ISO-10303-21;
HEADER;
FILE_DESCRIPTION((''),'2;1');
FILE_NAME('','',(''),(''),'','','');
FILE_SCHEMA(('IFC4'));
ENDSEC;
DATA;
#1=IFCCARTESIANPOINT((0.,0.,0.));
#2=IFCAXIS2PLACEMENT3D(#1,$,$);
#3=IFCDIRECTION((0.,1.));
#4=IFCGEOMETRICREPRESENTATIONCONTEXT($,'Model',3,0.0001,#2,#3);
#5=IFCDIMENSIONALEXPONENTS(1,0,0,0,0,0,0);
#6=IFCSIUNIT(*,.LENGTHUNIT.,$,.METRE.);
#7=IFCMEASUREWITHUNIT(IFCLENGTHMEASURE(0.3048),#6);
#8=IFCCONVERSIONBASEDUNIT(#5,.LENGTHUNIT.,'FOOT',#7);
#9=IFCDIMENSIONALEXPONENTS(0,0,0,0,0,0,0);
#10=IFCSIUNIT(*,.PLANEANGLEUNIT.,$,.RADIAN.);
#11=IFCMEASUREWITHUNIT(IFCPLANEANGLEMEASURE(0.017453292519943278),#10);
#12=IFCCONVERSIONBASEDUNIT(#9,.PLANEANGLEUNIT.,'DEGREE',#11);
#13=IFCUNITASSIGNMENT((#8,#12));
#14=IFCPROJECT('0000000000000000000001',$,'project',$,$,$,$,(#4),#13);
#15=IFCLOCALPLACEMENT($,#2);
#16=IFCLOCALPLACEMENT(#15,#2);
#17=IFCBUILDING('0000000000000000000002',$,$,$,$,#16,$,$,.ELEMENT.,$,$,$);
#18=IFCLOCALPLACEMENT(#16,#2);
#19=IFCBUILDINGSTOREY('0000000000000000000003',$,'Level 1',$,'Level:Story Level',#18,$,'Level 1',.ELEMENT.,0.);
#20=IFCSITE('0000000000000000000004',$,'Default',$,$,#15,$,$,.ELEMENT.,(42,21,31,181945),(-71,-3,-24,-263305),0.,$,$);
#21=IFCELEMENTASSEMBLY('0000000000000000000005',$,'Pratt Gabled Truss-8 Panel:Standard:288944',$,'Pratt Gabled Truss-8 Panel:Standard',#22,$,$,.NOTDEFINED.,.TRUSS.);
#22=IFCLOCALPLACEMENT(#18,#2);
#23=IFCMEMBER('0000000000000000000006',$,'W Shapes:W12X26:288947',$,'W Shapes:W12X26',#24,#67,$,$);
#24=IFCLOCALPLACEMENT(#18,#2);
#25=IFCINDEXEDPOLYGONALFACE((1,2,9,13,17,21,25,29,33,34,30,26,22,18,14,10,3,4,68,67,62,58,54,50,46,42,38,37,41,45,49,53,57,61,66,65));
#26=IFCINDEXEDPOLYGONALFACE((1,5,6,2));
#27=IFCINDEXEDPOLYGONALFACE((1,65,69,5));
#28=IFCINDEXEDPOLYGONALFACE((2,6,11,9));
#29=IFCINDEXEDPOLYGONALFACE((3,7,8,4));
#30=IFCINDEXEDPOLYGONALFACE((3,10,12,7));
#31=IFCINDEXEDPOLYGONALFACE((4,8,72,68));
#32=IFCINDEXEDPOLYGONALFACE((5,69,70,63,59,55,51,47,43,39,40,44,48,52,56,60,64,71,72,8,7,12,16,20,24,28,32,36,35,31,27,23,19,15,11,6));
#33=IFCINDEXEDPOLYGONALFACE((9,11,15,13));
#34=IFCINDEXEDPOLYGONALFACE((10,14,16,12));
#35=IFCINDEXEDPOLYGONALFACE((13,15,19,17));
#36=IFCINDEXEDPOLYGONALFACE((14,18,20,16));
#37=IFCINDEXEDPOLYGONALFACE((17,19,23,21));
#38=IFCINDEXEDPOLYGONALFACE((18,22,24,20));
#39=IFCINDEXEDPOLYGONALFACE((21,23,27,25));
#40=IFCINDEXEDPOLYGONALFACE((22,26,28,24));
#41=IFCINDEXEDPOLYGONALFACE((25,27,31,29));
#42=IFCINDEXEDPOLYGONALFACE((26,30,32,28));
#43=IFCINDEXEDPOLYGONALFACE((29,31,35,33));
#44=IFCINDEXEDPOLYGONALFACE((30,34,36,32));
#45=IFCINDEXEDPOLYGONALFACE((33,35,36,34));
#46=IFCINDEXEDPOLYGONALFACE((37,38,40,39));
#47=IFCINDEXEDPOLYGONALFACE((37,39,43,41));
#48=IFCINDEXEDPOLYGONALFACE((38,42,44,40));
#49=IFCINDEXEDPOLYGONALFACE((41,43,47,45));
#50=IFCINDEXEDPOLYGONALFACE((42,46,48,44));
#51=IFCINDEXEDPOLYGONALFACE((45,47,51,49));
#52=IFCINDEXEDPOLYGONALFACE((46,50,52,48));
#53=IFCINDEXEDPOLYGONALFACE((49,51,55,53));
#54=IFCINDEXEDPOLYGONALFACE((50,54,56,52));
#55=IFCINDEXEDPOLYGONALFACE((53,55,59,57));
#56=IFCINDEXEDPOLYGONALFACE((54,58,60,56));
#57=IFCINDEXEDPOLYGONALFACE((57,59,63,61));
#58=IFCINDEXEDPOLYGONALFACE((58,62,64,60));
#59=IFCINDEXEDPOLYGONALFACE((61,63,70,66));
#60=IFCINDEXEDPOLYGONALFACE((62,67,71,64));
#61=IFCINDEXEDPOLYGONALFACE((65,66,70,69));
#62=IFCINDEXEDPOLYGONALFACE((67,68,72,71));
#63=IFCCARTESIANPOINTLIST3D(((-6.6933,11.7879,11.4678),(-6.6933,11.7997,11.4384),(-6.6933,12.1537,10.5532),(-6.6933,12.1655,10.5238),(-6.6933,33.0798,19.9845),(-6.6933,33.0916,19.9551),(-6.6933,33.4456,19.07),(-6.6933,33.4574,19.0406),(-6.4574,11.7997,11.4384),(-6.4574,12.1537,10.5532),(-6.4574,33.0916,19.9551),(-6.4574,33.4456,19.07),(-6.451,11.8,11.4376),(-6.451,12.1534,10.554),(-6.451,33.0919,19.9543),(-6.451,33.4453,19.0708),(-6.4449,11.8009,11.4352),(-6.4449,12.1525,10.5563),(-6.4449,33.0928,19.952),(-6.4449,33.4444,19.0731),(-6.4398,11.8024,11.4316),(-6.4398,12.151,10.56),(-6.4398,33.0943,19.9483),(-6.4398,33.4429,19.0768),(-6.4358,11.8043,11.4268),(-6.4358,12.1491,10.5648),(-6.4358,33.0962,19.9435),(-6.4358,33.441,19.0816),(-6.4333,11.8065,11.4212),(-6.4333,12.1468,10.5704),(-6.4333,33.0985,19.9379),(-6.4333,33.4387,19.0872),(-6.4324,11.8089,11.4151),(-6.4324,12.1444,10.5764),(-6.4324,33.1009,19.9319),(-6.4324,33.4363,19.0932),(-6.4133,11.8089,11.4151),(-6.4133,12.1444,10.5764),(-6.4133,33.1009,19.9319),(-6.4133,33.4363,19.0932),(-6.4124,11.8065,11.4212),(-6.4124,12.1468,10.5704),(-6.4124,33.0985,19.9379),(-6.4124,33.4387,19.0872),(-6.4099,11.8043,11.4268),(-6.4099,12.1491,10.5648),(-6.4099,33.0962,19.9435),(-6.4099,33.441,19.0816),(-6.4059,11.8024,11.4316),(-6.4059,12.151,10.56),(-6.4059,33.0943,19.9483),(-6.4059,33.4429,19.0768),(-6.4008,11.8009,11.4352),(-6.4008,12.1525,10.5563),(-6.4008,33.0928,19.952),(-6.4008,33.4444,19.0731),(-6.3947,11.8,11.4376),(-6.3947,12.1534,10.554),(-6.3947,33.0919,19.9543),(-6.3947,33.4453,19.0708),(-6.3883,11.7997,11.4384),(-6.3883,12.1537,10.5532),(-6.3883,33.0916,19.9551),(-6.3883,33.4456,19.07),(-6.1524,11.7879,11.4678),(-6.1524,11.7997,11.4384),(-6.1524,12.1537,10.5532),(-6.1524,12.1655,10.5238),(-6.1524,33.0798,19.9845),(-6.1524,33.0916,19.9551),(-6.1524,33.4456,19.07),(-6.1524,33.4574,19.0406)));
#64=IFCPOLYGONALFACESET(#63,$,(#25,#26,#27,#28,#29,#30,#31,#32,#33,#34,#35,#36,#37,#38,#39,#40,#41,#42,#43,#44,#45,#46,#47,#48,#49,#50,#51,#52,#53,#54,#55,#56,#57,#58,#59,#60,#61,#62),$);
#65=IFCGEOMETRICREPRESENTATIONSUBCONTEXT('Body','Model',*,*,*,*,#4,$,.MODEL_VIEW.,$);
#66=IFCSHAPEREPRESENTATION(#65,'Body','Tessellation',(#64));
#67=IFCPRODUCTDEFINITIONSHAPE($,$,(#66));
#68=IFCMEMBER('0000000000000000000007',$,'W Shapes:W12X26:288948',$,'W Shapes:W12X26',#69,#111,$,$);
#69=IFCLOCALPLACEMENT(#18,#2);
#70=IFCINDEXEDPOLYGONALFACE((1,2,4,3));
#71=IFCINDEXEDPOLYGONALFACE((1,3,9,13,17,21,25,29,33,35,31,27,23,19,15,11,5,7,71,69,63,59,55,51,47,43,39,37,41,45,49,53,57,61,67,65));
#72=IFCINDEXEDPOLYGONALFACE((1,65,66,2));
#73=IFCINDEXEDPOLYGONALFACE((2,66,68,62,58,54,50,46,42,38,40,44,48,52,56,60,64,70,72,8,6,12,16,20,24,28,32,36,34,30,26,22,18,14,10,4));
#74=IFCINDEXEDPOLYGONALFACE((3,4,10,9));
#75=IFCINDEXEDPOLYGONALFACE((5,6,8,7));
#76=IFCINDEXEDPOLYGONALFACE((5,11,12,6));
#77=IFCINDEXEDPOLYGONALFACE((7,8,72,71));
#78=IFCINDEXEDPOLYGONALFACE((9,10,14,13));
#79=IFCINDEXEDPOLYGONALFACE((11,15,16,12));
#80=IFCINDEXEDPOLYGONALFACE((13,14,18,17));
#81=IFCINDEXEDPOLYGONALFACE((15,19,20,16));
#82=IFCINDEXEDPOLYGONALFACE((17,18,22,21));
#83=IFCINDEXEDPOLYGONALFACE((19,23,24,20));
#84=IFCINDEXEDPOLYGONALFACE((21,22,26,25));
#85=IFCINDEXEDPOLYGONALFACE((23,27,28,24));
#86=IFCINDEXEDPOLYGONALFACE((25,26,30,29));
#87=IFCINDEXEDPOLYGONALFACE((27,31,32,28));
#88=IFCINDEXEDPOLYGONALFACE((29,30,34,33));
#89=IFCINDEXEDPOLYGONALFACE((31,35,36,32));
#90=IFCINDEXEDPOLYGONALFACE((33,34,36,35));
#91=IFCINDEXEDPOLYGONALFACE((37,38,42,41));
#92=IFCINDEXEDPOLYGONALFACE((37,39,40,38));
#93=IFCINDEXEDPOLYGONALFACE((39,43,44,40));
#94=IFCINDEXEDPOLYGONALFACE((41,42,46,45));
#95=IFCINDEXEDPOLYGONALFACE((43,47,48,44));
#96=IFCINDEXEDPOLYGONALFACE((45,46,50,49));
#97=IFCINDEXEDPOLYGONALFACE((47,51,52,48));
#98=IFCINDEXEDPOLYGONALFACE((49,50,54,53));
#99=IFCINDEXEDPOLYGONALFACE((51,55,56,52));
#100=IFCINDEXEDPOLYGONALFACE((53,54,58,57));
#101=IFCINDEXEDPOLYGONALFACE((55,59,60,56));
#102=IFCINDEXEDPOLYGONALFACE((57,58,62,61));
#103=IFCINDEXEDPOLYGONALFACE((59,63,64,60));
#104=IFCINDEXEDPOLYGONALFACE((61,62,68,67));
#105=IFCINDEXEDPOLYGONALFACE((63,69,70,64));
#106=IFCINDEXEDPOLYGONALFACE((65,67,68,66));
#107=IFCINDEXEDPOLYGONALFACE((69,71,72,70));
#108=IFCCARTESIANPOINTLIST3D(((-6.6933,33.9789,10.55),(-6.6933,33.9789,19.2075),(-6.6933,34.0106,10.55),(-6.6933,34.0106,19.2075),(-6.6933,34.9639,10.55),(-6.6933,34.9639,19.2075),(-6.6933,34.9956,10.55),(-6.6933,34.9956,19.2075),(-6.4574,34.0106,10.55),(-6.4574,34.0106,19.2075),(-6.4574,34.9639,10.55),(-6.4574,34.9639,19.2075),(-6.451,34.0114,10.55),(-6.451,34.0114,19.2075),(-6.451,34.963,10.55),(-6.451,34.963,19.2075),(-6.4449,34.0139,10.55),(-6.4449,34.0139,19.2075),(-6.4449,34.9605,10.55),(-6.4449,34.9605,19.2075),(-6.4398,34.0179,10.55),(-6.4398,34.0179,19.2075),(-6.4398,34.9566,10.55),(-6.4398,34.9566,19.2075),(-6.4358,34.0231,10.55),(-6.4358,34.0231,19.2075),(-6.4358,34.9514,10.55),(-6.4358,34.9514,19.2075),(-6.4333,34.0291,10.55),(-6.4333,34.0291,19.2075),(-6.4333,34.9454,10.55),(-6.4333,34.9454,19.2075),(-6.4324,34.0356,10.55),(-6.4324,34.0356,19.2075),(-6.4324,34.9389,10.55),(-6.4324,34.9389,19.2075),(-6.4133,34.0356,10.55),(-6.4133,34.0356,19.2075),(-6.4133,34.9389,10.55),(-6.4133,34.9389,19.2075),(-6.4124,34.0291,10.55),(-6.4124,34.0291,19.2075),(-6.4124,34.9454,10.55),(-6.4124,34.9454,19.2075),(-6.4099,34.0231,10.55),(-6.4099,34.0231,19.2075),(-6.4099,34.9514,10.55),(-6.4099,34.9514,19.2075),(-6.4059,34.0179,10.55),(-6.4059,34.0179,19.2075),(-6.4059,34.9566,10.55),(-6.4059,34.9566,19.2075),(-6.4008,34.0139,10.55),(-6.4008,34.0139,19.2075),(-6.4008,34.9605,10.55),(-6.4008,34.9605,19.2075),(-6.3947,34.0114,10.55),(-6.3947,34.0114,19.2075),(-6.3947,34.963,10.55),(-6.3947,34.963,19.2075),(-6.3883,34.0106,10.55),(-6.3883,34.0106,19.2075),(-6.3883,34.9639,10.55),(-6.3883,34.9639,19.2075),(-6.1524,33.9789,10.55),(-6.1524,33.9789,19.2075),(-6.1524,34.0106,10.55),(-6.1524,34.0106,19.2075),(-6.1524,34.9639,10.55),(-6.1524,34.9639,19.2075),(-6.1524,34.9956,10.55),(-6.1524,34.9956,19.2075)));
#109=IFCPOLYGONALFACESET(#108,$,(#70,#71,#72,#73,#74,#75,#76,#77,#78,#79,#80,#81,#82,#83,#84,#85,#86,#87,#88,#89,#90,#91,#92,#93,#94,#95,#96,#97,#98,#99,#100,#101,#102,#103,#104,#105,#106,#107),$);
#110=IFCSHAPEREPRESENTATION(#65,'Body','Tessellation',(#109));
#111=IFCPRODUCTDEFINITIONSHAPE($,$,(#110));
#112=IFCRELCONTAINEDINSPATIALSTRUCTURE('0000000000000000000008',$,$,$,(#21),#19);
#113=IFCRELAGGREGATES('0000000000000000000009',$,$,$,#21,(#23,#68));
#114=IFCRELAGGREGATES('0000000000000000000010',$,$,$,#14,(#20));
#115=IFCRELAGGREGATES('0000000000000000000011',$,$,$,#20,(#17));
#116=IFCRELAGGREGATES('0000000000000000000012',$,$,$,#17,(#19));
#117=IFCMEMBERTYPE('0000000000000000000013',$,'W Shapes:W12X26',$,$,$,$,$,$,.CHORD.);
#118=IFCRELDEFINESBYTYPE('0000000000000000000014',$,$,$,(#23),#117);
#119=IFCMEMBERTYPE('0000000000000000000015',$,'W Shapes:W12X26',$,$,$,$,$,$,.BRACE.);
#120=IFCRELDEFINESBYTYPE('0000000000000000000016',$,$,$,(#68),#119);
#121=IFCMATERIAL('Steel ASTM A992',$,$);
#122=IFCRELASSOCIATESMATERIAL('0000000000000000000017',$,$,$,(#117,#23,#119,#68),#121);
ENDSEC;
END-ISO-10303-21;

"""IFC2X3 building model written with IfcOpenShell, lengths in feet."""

from ifc_helpers import new_model, entity, si_unit, converted_unit, direction, frame, frame_2d, origin, place, context, subcontext, project, spatial, polyline, circle_curve, parameter, trimmed, segment, composite_curve, outline, extrude, source, transform, mapped, material, type_object, type_shapes, element, aggregate, save


model = new_model("IFC2X3")

# Units and contexts
model_context = context("Model", 3, precision=0.0001, world=origin(), true_north=direction((0.0, 1.0)))
body_context = subcontext(model_context, "Body", "Model", "MODEL_VIEW")
ifc_project = project(units=[converted_unit("LENGTHUNIT", "FOOT", entity("IfcLengthMeasure", 0.3048), si_unit("LENGTHUNIT", "METRE"), dimensions=[1, 0, 0, 0, 0, 0, 0]), converted_unit("PLANEANGLEUNIT", "DEGREE", entity("IfcPlaneAngleMeasure", 0.017453292519943278), si_unit("PLANEANGLEUNIT", "RADIAN"), dimensions=[0, 0, 0, 0, 0, 0, 0])], contexts=[model_context])

# Site, building, storey
site_placement = place(None, origin())
site = spatial("IfcSite", under=ifc_project, at=site_placement, Name="Default", CompositionType="ELEMENT", RefLatitude=(42, 21, 31, 181945), RefLongitude=(-71, -3, -24, -263305), RefElevation=0.0)
building_placement = place(site_placement, origin())
building = spatial("IfcBuilding", under=site, at=building_placement, CompositionType="ELEMENT")
storey_placement = place(building_placement, origin())
storey = spatial("IfcBuildingStorey", under=building, at=storey_placement, Name="Level 1", ObjectType="Level:Story Level", LongName="Level 1", CompositionType="ELEMENT", Elevation=0.0)

# Element assembly, members
assembly_placement = place(storey_placement, origin())
assembly = element("IfcElementAssembly", 1, at=assembly_placement, inside=storey, Name="Pratt Gabled Truss-8 Panel:Standard:288944", ObjectType="Pratt Gabled Truss-8 Panel:Standard", AssemblyPlace="NOTDEFINED", PredefinedType="TRUSS")
ifc_material = material(Name="Steel ASTM A992")
member_type_1 = type_object("IfcMemberType", Name="W Shapes:W12X26", PredefinedType="CHORD", material=ifc_material)
shared_shape_1 = source(origin(), body_context, "Body", "SweptSolid", [
    extrude(outline(composite_curve([segment(polyline([(0.4767, -0.2704), (0.5083, -0.2704)]), True, "CONTINUOUS"), segment(polyline([(0.5083, -0.2704), (0.5083, 0.2704)]), True, "CONTINUOUS"), segment(polyline([(0.5083, 0.2704), (0.4767, 0.2704)]), True, "CONTINUOUS"), segment(polyline([(0.4767, 0.2704), (0.4767, 0.0346)]), True, "CONTINUOUS"), segment(trimmed(circle_curve(frame_2d((0.4517, 0.0346), x_axis=(1.0, 0.0)), 0.025), [parameter(270.0)], [parameter(0.0)], True, "PARAMETER"), False, "CONTINUOUS"), segment(polyline([(0.4517, 0.0096), (-0.4517, 0.0096)]), True, "CONTINUOUS"), segment(trimmed(circle_curve(frame_2d((-0.4517, 0.0346), x_axis=(0.0, -1.0)), 0.025), [parameter(270.0)], [parameter(0.0)], True, "PARAMETER"), False, "CONTINUOUS"), segment(polyline([(-0.4767, 0.0346), (-0.4767, 0.2704)]), True, "CONTINUOUS"), segment(polyline([(-0.4767, 0.2704), (-0.5083, 0.2704)]), True, "CONTINUOUS"), segment(polyline([(-0.5083, 0.2704), (-0.5083, -0.2704)]), True, "CONTINUOUS"), segment(polyline([(-0.5083, -0.2704), (-0.4767, -0.2704)]), True, "CONTINUOUS"), segment(polyline([(-0.4767, -0.2704), (-0.4767, -0.0346)]), True, "CONTINUOUS"), segment(trimmed(circle_curve(frame_2d((-0.4517, -0.0346), x_axis=(-1.0, 0.0)), 0.025), [parameter(270.0)], [parameter(0.0)], True, "PARAMETER"), False, "CONTINUOUS"), segment(polyline([(-0.4517, -0.0096), (0.4517, -0.0096)]), True, "CONTINUOUS"), segment(trimmed(circle_curve(frame_2d((0.4517, -0.0346), x_axis=(0.0, 1.0)), 0.025), [parameter(270.0)], [parameter(0.0)], True, "PARAMETER"), False, "CONTINUOUS"), segment(polyline([(0.4767, -0.0346), (0.4767, -0.2704)]), True, "CONTINUOUS")], self_intersect=False)), frame((-6.4228, 11.9767, 10.9958), z_axis=(0.0, 0.928477, 0.371391), x_axis=(0.0, -0.371391, 0.928477)), (0.0, 0.0, 1.0), 22.9321),
])
type_shapes(member_type_1, [shared_shape_1])
member_1_placement = place(assembly_placement, origin())
member_1 = element("IfcMember", 2, at=member_1_placement, type_object=member_type_1, material=ifc_material, Name="W Shapes:W12X26:288947", ObjectType="W Shapes:W12X26", context=body_context, shape_type="MappedRepresentation", body=[
    mapped(shared_shape_1, transform((0.0, 0.0, 0.0), scale=1.0)),
])
member_type_2 = type_object("IfcMemberType", Name="W Shapes:W12X26", PredefinedType="BRACE", material=ifc_material)
shared_shape_2 = source(origin(), body_context, "Body", "SweptSolid", [
    extrude(outline(composite_curve([segment(polyline([(-0.2704, -0.4767), (-0.2704, -0.5083)]), True, "CONTINUOUS"), segment(polyline([(-0.2704, -0.5083), (0.2704, -0.5083)]), True, "CONTINUOUS"), segment(polyline([(0.2704, -0.5083), (0.2704, -0.4767)]), True, "CONTINUOUS"), segment(polyline([(0.2704, -0.4767), (0.0346, -0.4767)]), True, "CONTINUOUS"), segment(trimmed(circle_curve(frame_2d((0.0346, -0.4517), x_axis=(1.0, 0.0)), 0.025), [parameter(180.0)], [parameter(270.0)], True, "PARAMETER"), False, "CONTINUOUS"), segment(polyline([(0.0096, -0.4517), (0.0096, 0.4517)]), True, "CONTINUOUS"), segment(trimmed(circle_curve(frame_2d((0.0346, 0.4517), x_axis=(1.0, 0.0)), 0.025), [parameter(90.0)], [parameter(180.0)], True, "PARAMETER"), False, "CONTINUOUS"), segment(polyline([(0.0346, 0.4767), (0.2704, 0.4767)]), True, "CONTINUOUS"), segment(polyline([(0.2704, 0.4767), (0.2704, 0.5083)]), True, "CONTINUOUS"), segment(polyline([(0.2704, 0.5083), (-0.2704, 0.5083)]), True, "CONTINUOUS"), segment(polyline([(-0.2704, 0.5083), (-0.2704, 0.4767)]), True, "CONTINUOUS"), segment(polyline([(-0.2704, 0.4767), (-0.0346, 0.4767)]), True, "CONTINUOUS"), segment(trimmed(circle_curve(frame_2d((-0.0346, 0.4517), x_axis=(1.0, 0.0)), 0.025), [parameter(360.0)], [parameter(90.0)], True, "PARAMETER"), False, "CONTINUOUS"), segment(polyline([(-0.0096, 0.4517), (-0.0096, -0.4517)]), True, "CONTINUOUS"), segment(trimmed(circle_curve(frame_2d((-0.0346, -0.4517), x_axis=(1.0, 0.0)), 0.025), [parameter(270.0)], [parameter(360.0)], True, "PARAMETER"), False, "CONTINUOUS"), segment(polyline([(-0.0346, -0.4767), (-0.2704, -0.4767)]), True, "CONTINUOUS")], self_intersect=False)), frame((-4.45, 0.0, 0.0), z_axis=(-1.0, 0.0, 0.0), x_axis=(0.0, -1.0, 0.0)), (0.0, 0.0, -1.0), 8.6575),
])
type_shapes(member_type_2, [shared_shape_2])
member_2_placement = place(assembly_placement, frame((-6.4228, 34.4872, 15.0), z_axis=(0.0, 1.0, 0.0), x_axis=(0.0, 0.0, 1.0)))
member_2 = element("IfcMember", 3, at=member_2_placement, type_object=member_type_2, material=ifc_material, Name="W Shapes:W12X26:288948", ObjectType="W Shapes:W12X26", context=body_context, shape_type="MappedRepresentation", body=[
    mapped(shared_shape_2, transform((0.0, 0.0, 0.0), scale=1.0)),
])
aggregate(assembly, [member_1, member_2])

save(model, "model.ifc")
